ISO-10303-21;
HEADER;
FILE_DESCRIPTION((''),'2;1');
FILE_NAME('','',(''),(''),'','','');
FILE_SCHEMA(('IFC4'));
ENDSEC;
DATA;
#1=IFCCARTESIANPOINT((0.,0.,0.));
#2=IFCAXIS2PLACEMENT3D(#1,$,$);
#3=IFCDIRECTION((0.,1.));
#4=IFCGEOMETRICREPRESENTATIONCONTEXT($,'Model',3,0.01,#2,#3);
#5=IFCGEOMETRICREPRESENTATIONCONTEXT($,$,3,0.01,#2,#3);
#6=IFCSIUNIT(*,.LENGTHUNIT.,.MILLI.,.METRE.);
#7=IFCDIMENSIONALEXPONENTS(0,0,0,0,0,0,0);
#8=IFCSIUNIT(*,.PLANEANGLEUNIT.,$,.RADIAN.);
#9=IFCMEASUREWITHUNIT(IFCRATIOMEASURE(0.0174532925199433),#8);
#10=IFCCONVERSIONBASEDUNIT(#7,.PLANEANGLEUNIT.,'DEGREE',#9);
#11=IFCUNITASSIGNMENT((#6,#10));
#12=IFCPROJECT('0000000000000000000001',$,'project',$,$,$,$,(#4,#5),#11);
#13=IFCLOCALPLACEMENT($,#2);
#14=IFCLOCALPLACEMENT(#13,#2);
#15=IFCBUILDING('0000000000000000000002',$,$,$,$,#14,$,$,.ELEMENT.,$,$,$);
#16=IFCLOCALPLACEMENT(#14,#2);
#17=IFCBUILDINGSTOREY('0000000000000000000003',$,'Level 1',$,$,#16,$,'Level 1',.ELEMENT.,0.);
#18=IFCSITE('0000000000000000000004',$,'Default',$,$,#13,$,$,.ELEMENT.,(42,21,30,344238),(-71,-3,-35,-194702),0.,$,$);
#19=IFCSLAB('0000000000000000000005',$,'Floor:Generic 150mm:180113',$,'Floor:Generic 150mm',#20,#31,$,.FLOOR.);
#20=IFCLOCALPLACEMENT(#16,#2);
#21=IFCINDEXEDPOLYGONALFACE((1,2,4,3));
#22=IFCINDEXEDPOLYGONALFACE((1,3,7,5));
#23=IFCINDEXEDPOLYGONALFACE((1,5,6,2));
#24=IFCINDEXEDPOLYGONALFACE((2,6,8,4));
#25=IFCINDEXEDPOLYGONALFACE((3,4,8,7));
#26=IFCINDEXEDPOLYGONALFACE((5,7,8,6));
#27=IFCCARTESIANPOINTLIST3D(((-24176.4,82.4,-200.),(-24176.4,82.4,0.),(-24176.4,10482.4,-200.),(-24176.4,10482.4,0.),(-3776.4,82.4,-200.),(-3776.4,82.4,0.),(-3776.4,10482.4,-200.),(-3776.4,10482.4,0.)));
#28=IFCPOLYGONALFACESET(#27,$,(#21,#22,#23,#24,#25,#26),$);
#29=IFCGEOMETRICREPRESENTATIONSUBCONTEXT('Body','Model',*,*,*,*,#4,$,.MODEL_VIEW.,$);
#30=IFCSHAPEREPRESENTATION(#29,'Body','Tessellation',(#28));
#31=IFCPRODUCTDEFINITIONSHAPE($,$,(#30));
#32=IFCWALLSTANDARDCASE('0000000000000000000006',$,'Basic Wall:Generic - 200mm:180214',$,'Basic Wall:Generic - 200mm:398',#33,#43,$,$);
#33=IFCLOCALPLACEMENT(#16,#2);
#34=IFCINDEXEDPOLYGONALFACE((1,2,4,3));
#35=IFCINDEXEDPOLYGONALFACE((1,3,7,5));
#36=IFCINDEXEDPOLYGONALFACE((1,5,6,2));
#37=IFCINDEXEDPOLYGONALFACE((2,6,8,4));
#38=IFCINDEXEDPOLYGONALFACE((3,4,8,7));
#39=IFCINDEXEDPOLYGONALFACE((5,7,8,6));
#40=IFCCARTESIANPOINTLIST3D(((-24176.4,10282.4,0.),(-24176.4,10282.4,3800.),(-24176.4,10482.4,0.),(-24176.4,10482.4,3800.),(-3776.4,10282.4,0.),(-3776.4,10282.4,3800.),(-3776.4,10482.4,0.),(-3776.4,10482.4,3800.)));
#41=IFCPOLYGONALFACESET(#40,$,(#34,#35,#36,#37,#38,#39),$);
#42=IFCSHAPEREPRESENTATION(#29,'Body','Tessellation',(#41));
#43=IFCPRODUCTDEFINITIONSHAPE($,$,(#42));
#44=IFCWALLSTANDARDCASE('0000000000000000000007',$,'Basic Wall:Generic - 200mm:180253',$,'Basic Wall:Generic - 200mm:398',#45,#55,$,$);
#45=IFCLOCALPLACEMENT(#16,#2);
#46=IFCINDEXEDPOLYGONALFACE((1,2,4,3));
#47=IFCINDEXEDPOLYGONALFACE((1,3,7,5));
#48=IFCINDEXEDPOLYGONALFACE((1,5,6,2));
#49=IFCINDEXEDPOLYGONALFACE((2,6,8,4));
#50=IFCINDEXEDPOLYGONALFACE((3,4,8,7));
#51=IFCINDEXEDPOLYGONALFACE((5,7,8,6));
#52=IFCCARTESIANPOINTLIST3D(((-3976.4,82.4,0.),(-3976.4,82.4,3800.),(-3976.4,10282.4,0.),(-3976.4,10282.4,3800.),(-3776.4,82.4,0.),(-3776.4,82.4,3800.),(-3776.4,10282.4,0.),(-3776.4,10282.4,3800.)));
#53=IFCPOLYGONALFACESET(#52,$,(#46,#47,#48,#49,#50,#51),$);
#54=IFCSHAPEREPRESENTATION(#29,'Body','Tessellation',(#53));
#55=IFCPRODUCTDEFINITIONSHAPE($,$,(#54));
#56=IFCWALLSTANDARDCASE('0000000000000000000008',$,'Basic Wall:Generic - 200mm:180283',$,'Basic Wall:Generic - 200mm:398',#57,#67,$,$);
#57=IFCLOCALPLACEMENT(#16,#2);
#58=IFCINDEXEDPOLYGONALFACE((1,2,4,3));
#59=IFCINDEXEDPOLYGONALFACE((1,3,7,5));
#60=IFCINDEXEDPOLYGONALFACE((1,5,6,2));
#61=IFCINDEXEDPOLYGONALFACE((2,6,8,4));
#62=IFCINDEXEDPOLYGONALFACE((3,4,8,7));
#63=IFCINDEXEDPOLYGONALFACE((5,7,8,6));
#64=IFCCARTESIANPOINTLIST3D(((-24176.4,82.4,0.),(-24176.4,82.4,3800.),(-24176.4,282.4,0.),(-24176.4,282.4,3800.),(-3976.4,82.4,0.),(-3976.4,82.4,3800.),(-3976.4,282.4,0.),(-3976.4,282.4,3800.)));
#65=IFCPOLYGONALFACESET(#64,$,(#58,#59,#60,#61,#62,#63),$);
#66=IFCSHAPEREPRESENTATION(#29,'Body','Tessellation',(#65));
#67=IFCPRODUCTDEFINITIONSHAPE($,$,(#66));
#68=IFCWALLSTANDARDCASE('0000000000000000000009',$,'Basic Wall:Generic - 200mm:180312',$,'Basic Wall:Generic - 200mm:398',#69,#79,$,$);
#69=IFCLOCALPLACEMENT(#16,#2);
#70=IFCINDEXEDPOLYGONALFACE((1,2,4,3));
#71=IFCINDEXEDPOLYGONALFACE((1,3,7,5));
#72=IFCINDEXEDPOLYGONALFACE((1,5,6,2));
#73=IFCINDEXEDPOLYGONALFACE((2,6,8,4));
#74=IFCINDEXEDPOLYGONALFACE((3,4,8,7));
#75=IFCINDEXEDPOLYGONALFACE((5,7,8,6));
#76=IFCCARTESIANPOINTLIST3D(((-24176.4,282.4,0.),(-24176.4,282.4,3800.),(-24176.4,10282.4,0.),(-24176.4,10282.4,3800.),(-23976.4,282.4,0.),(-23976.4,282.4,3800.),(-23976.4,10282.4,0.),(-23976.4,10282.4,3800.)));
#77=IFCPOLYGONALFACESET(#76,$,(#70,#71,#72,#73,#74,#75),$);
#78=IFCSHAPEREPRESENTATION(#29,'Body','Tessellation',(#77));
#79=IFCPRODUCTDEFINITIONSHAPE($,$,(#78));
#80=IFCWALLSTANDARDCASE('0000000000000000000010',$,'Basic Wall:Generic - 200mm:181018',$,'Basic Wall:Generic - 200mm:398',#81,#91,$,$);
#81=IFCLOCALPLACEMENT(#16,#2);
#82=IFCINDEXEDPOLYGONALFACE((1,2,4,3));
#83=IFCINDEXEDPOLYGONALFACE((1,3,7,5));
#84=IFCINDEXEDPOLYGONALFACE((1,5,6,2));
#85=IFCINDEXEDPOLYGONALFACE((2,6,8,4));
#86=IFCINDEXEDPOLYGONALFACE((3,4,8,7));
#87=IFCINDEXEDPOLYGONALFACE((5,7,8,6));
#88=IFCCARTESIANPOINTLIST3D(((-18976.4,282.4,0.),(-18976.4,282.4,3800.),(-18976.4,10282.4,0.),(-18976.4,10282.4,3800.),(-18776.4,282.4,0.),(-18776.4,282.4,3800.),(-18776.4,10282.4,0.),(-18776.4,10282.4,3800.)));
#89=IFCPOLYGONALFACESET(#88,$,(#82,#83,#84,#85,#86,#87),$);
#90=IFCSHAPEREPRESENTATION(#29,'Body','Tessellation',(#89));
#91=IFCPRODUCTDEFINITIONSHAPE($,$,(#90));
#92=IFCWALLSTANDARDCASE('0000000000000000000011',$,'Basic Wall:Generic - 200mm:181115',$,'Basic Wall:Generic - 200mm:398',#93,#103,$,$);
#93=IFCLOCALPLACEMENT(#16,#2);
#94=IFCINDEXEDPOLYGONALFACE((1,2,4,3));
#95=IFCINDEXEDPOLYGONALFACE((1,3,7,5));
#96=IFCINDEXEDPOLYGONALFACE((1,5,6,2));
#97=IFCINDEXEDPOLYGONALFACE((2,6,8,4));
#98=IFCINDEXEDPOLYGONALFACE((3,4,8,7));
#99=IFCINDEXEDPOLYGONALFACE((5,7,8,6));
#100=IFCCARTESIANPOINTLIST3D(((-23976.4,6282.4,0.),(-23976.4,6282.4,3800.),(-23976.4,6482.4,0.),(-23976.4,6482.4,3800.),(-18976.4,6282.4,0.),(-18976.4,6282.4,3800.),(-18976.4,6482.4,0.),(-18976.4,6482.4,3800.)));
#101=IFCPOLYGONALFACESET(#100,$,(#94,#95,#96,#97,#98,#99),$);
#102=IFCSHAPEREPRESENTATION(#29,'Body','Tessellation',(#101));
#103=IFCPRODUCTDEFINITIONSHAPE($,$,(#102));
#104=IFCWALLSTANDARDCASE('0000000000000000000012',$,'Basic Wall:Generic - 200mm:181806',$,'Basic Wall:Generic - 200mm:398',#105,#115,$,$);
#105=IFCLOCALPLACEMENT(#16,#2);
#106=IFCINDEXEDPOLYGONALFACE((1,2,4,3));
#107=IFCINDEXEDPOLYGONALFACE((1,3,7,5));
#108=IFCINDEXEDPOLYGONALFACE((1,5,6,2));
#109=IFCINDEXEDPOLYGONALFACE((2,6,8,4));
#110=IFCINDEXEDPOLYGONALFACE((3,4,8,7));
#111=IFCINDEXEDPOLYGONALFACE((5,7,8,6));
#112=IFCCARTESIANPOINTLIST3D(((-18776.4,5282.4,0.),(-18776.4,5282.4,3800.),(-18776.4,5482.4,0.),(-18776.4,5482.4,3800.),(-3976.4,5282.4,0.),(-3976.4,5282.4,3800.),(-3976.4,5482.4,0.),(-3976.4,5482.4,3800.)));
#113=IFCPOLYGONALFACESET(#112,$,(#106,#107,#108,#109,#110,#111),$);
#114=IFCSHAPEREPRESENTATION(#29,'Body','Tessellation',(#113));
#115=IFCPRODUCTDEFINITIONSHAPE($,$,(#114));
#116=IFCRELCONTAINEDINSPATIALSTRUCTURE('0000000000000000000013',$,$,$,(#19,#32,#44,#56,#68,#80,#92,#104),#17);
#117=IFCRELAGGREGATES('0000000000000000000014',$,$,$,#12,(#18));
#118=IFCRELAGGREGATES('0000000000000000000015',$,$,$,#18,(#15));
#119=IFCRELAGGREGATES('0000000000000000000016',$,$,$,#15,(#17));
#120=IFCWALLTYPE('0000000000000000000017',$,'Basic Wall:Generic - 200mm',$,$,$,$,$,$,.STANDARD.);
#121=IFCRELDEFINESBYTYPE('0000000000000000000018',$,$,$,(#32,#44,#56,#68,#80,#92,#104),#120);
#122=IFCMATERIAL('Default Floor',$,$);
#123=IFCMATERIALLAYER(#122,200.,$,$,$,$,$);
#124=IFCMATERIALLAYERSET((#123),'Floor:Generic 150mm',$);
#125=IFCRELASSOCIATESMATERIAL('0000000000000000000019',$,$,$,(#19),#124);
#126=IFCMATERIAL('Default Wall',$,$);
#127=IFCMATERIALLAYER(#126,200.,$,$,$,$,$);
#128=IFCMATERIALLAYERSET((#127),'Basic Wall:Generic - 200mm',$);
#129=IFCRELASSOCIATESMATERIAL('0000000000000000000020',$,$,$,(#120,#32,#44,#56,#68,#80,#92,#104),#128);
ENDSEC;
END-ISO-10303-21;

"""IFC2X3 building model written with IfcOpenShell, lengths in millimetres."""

from ifc_helpers import new_model, entity, si_unit, converted_unit, direction, frame, frame_2d, origin, origin_2d_with_axis, place, context, subcontext, project, spatial, rectangle, extrude, material, layer, layer_set, layer_usage, type_object, element, save


model = new_model("IFC2X3")

# Units and contexts
model_context = context("Model", 3, precision=0.01, world=origin(), true_north=direction((0.0, 1.0)))
context_of_model = context(None, 3, precision=0.01, world=origin(), true_north=direction((0.0, 1.0)))
body_context = subcontext(model_context, "Body", "Model", "MODEL_VIEW")
ifc_project = project(units=[si_unit("LENGTHUNIT", "METRE", prefix="MILLI"), converted_unit("PLANEANGLEUNIT", "DEGREE", entity("IfcRatioMeasure", 0.0174532925199433), si_unit("PLANEANGLEUNIT", "RADIAN"), dimensions=[0, 0, 0, 0, 0, 0, 0])], contexts=[model_context, context_of_model])

# Site, building, storey
site_placement = place(None, origin())
site = spatial("IfcSite", under=ifc_project, at=site_placement, Name="Default", CompositionType="ELEMENT", RefLatitude=(42, 21, 30, 344238), RefLongitude=(-71, -3, -35, -194702), RefElevation=0.0)
building_placement = place(site_placement, origin())
building = spatial("IfcBuilding", under=site, at=building_placement, CompositionType="ELEMENT")
storey_placement = place(building_placement, origin())
storey = spatial("IfcBuildingStorey", under=building, at=storey_placement, Name="Level 1", LongName="Level 1", CompositionType="ELEMENT", Elevation=0.0)

# Slab
ifc_material_1 = material(Name="Default Floor")
ifc_layer_1 = layer(ifc_material_1, 200.0)
ifc_layer_set_1 = layer_set([ifc_layer_1], Name="Floor:Generic 150mm")
ifc_layer_usage_1 = layer_usage(ifc_layer_set_1, "AXIS3", "POSITIVE", 0.0)
slab_placement = place(storey_placement, origin())
element("IfcSlab", 1, at=slab_placement, inside=storey, material=ifc_layer_usage_1, Name="Floor:Generic 150mm:180113", ObjectType="Floor:Generic 150mm", PredefinedType="FLOOR", context=body_context, shape_type="SweptSolid", body=[
    extrude(rectangle(XDim=10400.0, YDim=20400.0, at=origin_2d_with_axis()), frame((-13976.4, 5282.4, 0.0), z_axis=(0.0, 0.0, -1.0), x_axis=(0.0, 1.0, 0.0)), (0.0, 0.0, 1.0), 200.0),
])

# Walls
ifc_material_2 = material(Name="Default Wall")
ifc_layer_2 = layer(ifc_material_2, 200.0)
ifc_layer_set_2 = layer_set([ifc_layer_2], Name="Basic Wall:Generic - 200mm")
ifc_layer_usage_2 = layer_usage(ifc_layer_set_2, "AXIS2", "NEGATIVE", 100.0)
wall_type = type_object("IfcWallType", Name="Basic Wall:Generic - 200mm", PredefinedType="STANDARD", material=ifc_layer_set_2)
wall_1_placement = place(storey_placement, frame((-24176.4, 10382.4, 0.0)))
element("IfcWallStandardCase", 2, at=wall_1_placement, inside=storey, type_object=wall_type, material=ifc_layer_usage_2, Name="Basic Wall:Generic - 200mm:180214", ObjectType="Basic Wall:Generic - 200mm:398", context=body_context, shape_type="SweptSolid", body=[
    extrude(rectangle(XDim=20400.0, YDim=200.0, at=frame_2d((10200.0, 0.0), x_axis=(-1.0, 0.0))), origin(), (0.0, 0.0, 1.0), 3800.0),
])
ifc_layer_usage_3 = layer_usage(ifc_layer_set_2, "AXIS2", "NEGATIVE", 100.0)
wall_2_placement = place(storey_placement, frame((-3876.4, 10282.4, 0.0), z_axis=(0.0, 0.0, 1.0), x_axis=(0.0, -1.0, 0.0)))
element("IfcWallStandardCase", 3, at=wall_2_placement, inside=storey, type_object=wall_type, material=ifc_layer_usage_3, Name="Basic Wall:Generic - 200mm:180253", ObjectType="Basic Wall:Generic - 200mm:398", context=body_context, shape_type="SweptSolid", body=[
    extrude(rectangle(XDim=10200.0, YDim=200.0, at=frame_2d((5100.0, 0.0), x_axis=(-1.0, 0.0))), origin(), (0.0, 0.0, 1.0), 3800.0),
])
ifc_layer_usage_4 = layer_usage(ifc_layer_set_2, "AXIS2", "NEGATIVE", 100.0)
wall_3_placement = place(storey_placement, frame((-3976.4, 182.4, 0.0), z_axis=(0.0, 0.0, 1.0), x_axis=(-1.0, 0.0, 0.0)))
element("IfcWallStandardCase", 4, at=wall_3_placement, inside=storey, type_object=wall_type, material=ifc_layer_usage_4, Name="Basic Wall:Generic - 200mm:180283", ObjectType="Basic Wall:Generic - 200mm:398", context=body_context, shape_type="SweptSolid", body=[
    extrude(rectangle(XDim=20200.0, YDim=200.0, at=frame_2d((10100.0, 0.0), x_axis=(-1.0, 0.0))), origin(), (0.0, 0.0, 1.0), 3800.0),
])
ifc_layer_usage_5 = layer_usage(ifc_layer_set_2, "AXIS2", "NEGATIVE", 100.0)
wall_4_placement = place(storey_placement, frame((-24076.4, 282.4, 0.0), z_axis=(0.0, 0.0, 1.0), x_axis=(0.0, 1.0, 0.0)))
element("IfcWallStandardCase", 5, at=wall_4_placement, inside=storey, type_object=wall_type, material=ifc_layer_usage_5, Name="Basic Wall:Generic - 200mm:180312", ObjectType="Basic Wall:Generic - 200mm:398", context=body_context, shape_type="SweptSolid", body=[
    extrude(rectangle(XDim=10000.0, YDim=200.0, at=frame_2d((5000.0, 0.0), x_axis=(-1.0, 0.0))), origin(), (0.0, 0.0, 1.0), 3800.0),
])
ifc_layer_usage_6 = layer_usage(ifc_layer_set_2, "AXIS2", "NEGATIVE", 100.0)
wall_5_placement = place(storey_placement, frame((-18876.4, 10282.4, 0.0), z_axis=(0.0, 0.0, 1.0), x_axis=(0.0, -1.0, 0.0)))
element("IfcWallStandardCase", 6, at=wall_5_placement, inside=storey, type_object=wall_type, material=ifc_layer_usage_6, Name="Basic Wall:Generic - 200mm:181018", ObjectType="Basic Wall:Generic - 200mm:398", context=body_context, shape_type="SweptSolid", body=[
    extrude(rectangle(XDim=10000.0, YDim=200.0, at=frame_2d((5000.0, 0.0), x_axis=(-1.0, 0.0))), origin(), (0.0, 0.0, 1.0), 3800.0),
])
ifc_layer_usage_7 = layer_usage(ifc_layer_set_2, "AXIS2", "NEGATIVE", 100.0)
wall_6_placement = place(storey_placement, frame((-23976.4, 6382.4, 0.0)))
element("IfcWallStandardCase", 7, at=wall_6_placement, inside=storey, type_object=wall_type, material=ifc_layer_usage_7, Name="Basic Wall:Generic - 200mm:181115", ObjectType="Basic Wall:Generic - 200mm:398", context=body_context, shape_type="SweptSolid", body=[
    extrude(rectangle(XDim=5000.0, YDim=200.0, at=frame_2d((2500.0, 0.0), x_axis=(-1.0, 0.0))), origin(), (0.0, 0.0, 1.0), 3800.0),
])
ifc_layer_usage_8 = layer_usage(ifc_layer_set_2, "AXIS2", "NEGATIVE", 100.0)
wall_7_placement = place(storey_placement, frame((-18776.4, 5382.4, 0.0)))
element("IfcWallStandardCase", 8, at=wall_7_placement, inside=storey, type_object=wall_type, material=ifc_layer_usage_8, Name="Basic Wall:Generic - 200mm:181806", ObjectType="Basic Wall:Generic - 200mm:398", context=body_context, shape_type="SweptSolid", body=[
    extrude(rectangle(XDim=14800.0, YDim=200.0, at=frame_2d((7400.0, 0.0), x_axis=(-1.0, 0.0))), origin(), (0.0, 0.0, 1.0), 3800.0),
])

save(model, "model.ifc")
